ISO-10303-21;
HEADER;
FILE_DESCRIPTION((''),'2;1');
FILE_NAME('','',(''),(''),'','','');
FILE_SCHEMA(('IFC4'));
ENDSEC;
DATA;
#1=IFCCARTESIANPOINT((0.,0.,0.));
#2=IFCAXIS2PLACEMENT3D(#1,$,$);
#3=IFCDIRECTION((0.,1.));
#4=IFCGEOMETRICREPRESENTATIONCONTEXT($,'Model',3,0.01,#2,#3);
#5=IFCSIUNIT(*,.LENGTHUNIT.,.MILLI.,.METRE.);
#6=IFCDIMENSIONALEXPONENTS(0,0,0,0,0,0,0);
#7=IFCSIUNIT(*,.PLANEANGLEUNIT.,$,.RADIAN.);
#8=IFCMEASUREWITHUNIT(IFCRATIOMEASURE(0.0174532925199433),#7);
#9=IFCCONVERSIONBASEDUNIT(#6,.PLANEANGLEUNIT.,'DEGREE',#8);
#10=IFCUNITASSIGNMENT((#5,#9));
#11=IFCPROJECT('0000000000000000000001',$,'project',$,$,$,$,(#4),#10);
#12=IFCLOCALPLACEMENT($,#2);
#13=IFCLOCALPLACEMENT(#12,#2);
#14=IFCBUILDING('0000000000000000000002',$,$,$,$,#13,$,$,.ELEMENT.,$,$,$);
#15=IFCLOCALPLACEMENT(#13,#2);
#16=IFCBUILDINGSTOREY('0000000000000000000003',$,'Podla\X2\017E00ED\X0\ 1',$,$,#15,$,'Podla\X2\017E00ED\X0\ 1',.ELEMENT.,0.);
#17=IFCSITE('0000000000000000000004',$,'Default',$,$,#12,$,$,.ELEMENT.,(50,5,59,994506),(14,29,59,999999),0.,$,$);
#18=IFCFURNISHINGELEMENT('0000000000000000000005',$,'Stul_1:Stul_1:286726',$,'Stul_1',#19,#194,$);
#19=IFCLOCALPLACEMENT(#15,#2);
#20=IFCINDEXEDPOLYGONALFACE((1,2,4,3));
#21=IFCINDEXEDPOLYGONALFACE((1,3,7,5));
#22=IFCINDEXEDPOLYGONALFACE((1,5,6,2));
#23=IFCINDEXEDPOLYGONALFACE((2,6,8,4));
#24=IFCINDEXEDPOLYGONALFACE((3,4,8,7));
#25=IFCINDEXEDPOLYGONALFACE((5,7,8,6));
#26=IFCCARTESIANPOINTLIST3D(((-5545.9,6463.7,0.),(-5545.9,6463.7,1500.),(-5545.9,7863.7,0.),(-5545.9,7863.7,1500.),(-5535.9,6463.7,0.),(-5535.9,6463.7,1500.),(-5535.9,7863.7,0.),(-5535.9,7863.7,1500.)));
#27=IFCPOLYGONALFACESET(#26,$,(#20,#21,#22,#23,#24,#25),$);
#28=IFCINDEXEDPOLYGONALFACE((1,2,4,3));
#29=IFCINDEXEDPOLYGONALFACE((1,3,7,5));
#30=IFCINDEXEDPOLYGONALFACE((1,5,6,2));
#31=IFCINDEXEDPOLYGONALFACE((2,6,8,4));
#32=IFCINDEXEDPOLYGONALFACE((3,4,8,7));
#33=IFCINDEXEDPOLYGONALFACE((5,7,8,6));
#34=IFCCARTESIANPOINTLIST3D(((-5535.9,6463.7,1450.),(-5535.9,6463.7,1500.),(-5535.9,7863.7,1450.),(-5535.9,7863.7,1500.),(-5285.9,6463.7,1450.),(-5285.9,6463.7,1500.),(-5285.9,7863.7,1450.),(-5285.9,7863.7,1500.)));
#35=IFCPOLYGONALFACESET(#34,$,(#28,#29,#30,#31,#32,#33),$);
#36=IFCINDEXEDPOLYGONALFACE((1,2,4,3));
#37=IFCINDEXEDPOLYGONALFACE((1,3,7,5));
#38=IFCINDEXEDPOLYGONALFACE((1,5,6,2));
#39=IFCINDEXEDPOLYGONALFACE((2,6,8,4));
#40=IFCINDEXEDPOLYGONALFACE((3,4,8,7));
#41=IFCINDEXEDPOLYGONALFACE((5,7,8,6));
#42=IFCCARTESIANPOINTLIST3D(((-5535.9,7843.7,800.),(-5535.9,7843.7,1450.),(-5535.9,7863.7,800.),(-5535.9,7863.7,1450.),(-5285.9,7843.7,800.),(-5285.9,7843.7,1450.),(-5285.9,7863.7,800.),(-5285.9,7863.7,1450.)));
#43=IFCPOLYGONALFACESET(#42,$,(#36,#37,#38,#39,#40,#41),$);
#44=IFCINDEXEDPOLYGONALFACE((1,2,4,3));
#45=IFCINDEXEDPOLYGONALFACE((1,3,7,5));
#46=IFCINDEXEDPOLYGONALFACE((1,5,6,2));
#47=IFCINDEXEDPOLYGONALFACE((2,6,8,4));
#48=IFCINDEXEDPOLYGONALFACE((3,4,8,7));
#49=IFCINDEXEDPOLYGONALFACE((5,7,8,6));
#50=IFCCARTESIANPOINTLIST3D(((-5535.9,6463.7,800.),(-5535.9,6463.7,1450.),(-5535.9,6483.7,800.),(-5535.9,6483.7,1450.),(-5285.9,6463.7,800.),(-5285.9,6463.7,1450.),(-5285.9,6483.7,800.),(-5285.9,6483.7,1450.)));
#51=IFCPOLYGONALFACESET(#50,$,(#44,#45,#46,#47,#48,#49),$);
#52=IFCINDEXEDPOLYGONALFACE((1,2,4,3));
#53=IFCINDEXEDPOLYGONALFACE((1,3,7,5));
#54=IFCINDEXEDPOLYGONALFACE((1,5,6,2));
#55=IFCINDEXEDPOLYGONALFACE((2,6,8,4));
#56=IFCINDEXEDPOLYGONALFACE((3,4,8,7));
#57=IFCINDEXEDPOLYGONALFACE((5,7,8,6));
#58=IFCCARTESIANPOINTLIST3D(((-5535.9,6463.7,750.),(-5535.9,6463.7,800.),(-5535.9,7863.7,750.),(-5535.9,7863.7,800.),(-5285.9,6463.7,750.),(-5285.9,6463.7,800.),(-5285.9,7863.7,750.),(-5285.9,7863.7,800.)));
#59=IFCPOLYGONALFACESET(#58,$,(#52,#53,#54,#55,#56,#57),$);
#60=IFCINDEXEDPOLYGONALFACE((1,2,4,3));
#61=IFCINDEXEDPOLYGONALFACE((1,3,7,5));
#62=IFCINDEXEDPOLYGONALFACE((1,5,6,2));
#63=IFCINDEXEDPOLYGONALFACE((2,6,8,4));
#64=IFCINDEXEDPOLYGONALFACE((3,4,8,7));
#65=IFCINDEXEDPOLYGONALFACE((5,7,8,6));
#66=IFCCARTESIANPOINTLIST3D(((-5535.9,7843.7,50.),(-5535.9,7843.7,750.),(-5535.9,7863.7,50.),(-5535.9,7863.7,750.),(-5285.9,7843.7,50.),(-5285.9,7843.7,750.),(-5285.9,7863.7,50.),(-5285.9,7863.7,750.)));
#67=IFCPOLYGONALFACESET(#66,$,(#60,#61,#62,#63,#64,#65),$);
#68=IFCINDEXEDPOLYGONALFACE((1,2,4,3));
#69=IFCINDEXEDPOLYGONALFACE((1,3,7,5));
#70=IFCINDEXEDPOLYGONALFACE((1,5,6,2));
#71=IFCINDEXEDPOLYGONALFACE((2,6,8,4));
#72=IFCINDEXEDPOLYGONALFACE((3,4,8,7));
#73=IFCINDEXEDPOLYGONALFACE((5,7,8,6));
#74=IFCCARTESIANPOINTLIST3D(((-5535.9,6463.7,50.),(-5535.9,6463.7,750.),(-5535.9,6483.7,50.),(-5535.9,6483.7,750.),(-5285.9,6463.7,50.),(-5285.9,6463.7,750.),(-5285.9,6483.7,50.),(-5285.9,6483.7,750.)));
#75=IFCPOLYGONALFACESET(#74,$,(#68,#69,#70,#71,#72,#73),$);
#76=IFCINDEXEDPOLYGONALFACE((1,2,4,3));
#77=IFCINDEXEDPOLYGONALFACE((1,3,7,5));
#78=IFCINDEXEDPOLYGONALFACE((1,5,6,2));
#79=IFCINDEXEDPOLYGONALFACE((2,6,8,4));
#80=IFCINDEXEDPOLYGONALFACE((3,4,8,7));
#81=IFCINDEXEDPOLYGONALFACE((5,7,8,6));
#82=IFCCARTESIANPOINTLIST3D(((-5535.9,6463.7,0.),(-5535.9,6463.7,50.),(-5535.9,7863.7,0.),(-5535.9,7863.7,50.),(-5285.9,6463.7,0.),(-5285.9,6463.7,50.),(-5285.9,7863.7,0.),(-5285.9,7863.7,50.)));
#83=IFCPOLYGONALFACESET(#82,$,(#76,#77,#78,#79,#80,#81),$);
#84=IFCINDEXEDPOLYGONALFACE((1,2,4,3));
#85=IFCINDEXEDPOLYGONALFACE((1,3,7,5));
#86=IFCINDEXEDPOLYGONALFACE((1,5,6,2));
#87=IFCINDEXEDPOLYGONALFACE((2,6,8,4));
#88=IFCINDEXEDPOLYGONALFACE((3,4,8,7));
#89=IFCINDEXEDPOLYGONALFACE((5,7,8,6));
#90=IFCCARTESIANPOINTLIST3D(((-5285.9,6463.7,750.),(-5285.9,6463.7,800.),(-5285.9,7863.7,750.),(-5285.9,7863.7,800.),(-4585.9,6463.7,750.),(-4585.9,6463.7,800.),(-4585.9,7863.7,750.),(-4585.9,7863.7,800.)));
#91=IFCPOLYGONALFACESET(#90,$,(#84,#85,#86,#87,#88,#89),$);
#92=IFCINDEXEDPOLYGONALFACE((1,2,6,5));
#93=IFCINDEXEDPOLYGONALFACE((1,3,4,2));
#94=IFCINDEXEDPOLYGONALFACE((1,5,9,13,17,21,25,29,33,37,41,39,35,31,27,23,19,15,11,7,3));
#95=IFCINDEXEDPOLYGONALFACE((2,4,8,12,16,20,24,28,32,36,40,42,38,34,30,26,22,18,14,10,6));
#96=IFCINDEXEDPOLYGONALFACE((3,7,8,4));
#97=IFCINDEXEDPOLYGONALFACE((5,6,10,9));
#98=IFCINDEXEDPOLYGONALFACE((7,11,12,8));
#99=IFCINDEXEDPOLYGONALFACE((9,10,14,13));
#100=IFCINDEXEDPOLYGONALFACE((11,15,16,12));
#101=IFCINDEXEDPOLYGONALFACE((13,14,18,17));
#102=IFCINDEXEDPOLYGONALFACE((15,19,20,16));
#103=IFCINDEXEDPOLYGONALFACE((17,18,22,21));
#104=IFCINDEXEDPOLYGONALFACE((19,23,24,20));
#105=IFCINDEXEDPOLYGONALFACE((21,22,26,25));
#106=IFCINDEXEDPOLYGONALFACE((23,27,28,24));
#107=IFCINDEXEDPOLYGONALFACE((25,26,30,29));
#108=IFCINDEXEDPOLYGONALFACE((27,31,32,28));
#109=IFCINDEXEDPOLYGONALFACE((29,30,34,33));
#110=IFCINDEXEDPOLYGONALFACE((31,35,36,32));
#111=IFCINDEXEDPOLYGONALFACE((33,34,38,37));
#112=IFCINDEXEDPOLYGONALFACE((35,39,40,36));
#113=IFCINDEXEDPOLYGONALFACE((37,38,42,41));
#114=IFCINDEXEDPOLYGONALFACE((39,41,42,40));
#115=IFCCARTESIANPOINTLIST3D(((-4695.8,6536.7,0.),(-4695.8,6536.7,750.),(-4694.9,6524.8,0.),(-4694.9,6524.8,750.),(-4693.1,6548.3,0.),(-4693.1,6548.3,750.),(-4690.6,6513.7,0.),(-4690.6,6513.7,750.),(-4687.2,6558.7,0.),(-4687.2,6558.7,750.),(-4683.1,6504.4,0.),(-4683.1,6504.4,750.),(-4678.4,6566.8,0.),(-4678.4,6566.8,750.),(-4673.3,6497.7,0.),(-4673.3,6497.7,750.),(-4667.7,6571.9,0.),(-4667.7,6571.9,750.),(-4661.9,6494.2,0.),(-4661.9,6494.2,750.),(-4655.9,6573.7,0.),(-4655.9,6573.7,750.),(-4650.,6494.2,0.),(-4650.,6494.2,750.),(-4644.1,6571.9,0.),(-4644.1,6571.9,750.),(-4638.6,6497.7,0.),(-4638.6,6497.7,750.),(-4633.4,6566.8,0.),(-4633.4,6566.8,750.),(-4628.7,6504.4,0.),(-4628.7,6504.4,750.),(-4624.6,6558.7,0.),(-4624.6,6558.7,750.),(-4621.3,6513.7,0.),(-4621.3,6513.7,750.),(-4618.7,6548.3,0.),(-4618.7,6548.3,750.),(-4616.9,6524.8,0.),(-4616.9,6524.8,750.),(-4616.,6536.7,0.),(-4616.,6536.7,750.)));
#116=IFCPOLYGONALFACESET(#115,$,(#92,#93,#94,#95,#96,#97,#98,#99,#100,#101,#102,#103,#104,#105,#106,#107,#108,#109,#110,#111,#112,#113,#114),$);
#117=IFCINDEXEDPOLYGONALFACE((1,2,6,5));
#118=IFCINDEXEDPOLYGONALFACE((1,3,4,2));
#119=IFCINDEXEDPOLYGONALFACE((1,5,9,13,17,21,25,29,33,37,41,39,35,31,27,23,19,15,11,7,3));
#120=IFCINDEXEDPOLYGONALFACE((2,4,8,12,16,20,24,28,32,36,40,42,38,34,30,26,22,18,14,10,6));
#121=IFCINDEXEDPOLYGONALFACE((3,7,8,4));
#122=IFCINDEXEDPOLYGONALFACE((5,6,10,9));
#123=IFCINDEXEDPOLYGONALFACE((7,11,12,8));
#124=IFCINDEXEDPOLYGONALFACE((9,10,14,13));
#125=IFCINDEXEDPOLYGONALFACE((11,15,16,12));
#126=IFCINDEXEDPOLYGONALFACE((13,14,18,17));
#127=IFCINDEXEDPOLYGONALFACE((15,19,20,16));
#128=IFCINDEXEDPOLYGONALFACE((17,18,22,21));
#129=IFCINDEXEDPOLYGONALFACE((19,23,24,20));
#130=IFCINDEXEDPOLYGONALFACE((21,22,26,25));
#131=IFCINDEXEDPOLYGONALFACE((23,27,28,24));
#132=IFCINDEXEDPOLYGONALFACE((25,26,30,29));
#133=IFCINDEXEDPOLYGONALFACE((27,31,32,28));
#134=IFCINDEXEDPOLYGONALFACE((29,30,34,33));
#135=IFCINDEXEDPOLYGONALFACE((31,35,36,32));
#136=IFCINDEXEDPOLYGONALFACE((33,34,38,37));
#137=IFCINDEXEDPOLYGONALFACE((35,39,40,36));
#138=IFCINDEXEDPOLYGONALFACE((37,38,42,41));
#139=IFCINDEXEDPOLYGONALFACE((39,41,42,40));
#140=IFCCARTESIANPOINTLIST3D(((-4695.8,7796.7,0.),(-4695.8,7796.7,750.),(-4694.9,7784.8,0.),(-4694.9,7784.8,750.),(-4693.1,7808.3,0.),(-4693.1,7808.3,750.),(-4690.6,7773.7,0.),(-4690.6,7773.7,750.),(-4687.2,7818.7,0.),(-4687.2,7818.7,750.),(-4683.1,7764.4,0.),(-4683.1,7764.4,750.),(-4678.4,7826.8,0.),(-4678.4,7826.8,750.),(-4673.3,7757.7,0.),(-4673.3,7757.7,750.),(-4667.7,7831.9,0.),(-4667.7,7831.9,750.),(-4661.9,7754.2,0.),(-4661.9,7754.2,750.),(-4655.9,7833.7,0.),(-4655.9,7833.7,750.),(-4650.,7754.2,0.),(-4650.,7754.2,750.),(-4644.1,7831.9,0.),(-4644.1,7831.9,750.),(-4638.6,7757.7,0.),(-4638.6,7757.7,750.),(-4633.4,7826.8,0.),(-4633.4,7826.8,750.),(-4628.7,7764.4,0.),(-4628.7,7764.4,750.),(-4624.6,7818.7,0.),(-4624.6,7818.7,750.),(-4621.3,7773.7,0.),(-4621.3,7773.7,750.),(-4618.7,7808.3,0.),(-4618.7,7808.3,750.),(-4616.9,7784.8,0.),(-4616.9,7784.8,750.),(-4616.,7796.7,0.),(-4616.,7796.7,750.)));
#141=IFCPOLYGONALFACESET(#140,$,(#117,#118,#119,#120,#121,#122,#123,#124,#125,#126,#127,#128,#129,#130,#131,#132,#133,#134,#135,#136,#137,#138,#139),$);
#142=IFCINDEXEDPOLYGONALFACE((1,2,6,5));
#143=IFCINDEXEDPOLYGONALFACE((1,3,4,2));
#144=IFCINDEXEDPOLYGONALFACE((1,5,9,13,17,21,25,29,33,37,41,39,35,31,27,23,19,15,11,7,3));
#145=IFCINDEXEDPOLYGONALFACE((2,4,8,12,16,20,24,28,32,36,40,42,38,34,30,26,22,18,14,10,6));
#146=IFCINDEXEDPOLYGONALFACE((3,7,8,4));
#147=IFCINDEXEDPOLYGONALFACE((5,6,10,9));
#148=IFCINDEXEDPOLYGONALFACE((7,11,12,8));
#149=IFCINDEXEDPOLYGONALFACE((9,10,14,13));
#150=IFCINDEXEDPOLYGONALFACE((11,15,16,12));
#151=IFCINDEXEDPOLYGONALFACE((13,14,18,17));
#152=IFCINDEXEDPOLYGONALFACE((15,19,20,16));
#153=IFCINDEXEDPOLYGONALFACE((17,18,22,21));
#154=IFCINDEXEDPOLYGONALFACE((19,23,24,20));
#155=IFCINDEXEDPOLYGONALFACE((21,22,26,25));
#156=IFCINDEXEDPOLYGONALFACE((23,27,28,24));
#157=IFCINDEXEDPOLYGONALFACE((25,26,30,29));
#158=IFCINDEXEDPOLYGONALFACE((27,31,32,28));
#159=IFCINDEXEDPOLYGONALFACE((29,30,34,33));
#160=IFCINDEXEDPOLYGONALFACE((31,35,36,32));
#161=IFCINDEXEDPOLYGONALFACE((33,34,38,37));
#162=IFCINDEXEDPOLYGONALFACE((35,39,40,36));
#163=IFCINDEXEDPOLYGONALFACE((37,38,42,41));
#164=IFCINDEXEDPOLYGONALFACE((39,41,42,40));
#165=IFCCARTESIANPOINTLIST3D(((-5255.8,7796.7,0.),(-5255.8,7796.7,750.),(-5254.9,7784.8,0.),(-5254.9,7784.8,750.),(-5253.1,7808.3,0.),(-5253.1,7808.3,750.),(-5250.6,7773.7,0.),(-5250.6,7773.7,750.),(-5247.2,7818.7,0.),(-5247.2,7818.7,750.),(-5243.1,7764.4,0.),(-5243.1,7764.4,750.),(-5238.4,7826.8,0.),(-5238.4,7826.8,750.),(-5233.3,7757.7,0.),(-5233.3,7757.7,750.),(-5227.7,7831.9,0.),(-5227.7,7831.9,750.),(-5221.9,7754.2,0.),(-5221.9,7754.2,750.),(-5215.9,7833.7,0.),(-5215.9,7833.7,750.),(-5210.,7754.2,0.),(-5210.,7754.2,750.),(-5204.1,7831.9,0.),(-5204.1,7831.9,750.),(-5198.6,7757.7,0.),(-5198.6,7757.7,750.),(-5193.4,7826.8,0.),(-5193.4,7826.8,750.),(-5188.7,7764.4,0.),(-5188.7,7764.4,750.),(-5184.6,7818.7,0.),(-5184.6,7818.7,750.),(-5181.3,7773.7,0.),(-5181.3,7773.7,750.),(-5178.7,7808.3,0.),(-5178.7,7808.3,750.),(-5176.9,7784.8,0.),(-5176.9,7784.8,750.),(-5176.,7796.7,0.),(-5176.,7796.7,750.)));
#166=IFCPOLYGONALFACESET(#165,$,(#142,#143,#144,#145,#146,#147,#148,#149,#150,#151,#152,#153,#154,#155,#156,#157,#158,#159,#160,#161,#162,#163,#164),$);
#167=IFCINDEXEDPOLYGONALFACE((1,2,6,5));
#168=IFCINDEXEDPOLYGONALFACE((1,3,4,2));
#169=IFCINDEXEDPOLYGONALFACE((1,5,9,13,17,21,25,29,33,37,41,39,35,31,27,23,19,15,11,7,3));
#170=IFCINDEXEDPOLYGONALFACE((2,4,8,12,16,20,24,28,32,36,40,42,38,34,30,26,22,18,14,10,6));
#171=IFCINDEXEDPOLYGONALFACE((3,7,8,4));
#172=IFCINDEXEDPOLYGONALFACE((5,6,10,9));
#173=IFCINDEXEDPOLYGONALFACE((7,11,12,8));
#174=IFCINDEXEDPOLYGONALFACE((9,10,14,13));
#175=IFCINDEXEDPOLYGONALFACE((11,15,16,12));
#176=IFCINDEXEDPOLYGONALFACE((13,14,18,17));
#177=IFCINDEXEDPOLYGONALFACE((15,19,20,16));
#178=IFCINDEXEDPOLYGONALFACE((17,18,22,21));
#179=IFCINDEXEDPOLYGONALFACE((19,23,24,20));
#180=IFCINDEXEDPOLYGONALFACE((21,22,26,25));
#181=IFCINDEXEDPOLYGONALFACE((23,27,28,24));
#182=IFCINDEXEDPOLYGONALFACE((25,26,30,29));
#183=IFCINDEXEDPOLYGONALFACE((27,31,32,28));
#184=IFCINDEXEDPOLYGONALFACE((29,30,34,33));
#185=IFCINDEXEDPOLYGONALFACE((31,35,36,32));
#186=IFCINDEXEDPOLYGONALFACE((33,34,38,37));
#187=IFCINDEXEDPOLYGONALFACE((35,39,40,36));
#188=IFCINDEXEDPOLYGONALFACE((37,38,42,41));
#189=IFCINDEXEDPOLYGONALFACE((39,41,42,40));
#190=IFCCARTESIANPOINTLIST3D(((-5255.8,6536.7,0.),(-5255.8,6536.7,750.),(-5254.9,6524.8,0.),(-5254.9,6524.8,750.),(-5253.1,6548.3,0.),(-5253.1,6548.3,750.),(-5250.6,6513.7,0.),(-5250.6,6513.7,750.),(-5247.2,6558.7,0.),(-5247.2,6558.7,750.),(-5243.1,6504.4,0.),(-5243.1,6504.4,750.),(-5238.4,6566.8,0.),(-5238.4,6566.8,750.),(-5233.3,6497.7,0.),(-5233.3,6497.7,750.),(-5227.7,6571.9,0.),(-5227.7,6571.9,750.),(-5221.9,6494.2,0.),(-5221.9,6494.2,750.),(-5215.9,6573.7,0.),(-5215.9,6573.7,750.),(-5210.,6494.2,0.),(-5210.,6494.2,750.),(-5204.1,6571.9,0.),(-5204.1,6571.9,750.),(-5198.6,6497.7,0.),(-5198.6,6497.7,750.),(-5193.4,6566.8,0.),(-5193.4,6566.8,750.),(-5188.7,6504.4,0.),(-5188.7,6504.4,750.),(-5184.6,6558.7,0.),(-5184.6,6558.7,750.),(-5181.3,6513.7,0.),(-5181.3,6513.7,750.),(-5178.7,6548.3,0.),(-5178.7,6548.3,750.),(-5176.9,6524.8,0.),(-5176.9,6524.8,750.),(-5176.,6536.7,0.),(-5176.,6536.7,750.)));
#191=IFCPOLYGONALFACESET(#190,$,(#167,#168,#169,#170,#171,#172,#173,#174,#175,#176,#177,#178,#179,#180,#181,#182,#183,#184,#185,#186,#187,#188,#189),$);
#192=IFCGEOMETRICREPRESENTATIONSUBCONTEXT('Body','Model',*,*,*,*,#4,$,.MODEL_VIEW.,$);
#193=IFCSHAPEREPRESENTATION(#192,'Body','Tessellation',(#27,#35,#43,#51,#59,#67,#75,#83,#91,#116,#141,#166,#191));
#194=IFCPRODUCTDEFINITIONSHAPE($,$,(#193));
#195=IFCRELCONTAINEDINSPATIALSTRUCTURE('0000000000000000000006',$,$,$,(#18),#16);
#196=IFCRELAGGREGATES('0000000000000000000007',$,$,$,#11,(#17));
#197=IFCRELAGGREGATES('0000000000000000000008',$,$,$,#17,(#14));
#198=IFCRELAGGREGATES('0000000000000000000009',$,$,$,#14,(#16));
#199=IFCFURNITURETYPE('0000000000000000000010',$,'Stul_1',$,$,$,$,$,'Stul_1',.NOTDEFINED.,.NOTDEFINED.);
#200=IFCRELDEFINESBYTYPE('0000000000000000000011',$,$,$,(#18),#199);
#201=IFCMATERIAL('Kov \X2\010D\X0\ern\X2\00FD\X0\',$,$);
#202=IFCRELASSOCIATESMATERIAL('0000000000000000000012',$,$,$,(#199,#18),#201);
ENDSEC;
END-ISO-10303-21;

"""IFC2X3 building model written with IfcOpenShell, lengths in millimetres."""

from ifc_helpers import new_model, entity, si_unit, converted_unit, direction, frame, frame_2d, origin, origin_2d_with_axis, place, context, subcontext, project, spatial, rectangle, circle, extrude, source, transform, mapped, material, type_object, type_shapes, element, save


model = new_model("IFC2X3")

# Units and contexts
model_context = context("Model", 3, precision=0.01, world=origin(), true_north=direction((0.0, 1.0)))
body_context = subcontext(model_context, "Body", "Model", "MODEL_VIEW")
ifc_project = project(units=[si_unit("LENGTHUNIT", "METRE", prefix="MILLI"), converted_unit("PLANEANGLEUNIT", "DEGREE", entity("IfcRatioMeasure", 0.0174532925199433), si_unit("PLANEANGLEUNIT", "RADIAN"), dimensions=[0, 0, 0, 0, 0, 0, 0])], contexts=[model_context])

# Site, building, storey
site_placement = place(None, origin())
site = spatial("IfcSite", under=ifc_project, at=site_placement, Name="Default", CompositionType="ELEMENT", RefLatitude=(50, 5, 59, 994506), RefLongitude=(14, 29, 59, 999999), RefElevation=0.0)
building_placement = place(site_placement, origin())
building = spatial("IfcBuilding", under=site, at=building_placement, CompositionType="ELEMENT")
storey_placement = place(building_placement, origin())
storey = spatial("IfcBuildingStorey", under=building, at=storey_placement, Name="Podlaží 1", LongName="Podlaží 1", CompositionType="ELEMENT", Elevation=0.0)

# Furnishing element
ifc_material_1 = material(Name="Kov černý")
furniture_type = type_object("IfcFurnitureType", Name="Stul_1", ElementType="Stul_1", material=ifc_material_1)
shared_shape_1 = source(origin(), body_context, "Body", "SweptSolid", [
    extrude(rectangle(XDim=1400.0, YDim=10.0, at=origin_2d_with_axis()), frame((0.0, 605.0, 0.0), z_axis=(0.0, 0.0, 1.0), x_axis=(-1.0, 0.0, 0.0)), (0.0, 0.0, 1.0), 1500.0),
    extrude(rectangle(XDim=1400.0, YDim=250.0, at=frame_2d((0.0, 0.0), x_axis=(1.0, 0.0))), frame((0.0, 475.0, 1450.0), z_axis=(0.0, 0.0, 1.0), x_axis=(-1.0, 0.0, 0.0)), (0.0, 0.0, 1.0), 50.0),
    extrude(rectangle(XDim=20.0, YDim=250.0, at=origin_2d_with_axis()), frame((690.0, 475.0, 800.0), z_axis=(0.0, 0.0, 1.0), x_axis=(-1.0, 0.0, 0.0)), (0.0, 0.0, 1.0), 650.0),
    extrude(rectangle(XDim=20.0, YDim=250.0, at=frame_2d((0.0, 0.0), x_axis=(1.0, 0.0))), frame((-690.0, 475.0, 800.0), z_axis=(0.0, 0.0, 1.0), x_axis=(-1.0, 0.0, 0.0)), (0.0, 0.0, 1.0), 650.0),
    extrude(rectangle(XDim=1400.0, YDim=250.0, at=origin_2d_with_axis()), frame((0.0, 475.0, 750.0), z_axis=(0.0, 0.0, 1.0), x_axis=(-1.0, 0.0, 0.0)), (0.0, 0.0, 1.0), 50.0),
    extrude(rectangle(XDim=20.0, YDim=250.0, at=origin_2d_with_axis()), frame((690.0, 475.0, 50.0), z_axis=(0.0, 0.0, 1.0), x_axis=(-1.0, 0.0, 0.0)), (0.0, 0.0, 1.0), 700.0),
    extrude(rectangle(XDim=20.0, YDim=250.0, at=frame_2d((0.0, 0.0), x_axis=(1.0, 0.0))), frame((-690.0, 475.0, 50.0), z_axis=(0.0, 0.0, 1.0), x_axis=(-1.0, 0.0, 0.0)), (0.0, 0.0, 1.0), 700.0),
    extrude(rectangle(XDim=1400.0, YDim=250.0, at=origin_2d_with_axis()), frame((0.0, 475.0, 0.0), z_axis=(0.0, 0.0, 1.0), x_axis=(-1.0, 0.0, 0.0)), (0.0, 0.0, 1.0), 50.0),
    extrude(rectangle(XDim=1400.0, YDim=700.0, at=origin_2d_with_axis()), frame((0.0, 0.0, 750.0), z_axis=(0.0, 0.0, 1.0), x_axis=(-1.0, 0.0, 0.0)), (0.0, 0.0, 1.0), 50.0),
    extrude(circle(Radius=40.0, at=frame_2d((0.0, 0.0), x_axis=(1.0, 0.0))), frame((-630.0, -280.0, 0.0)), (0.0, 0.0, 1.0), 750.0),
    extrude(circle(Radius=40.0, at=frame_2d((0.0, 0.0), x_axis=(1.0, 0.0))), frame((630.0, -280.0, 0.0)), (0.0, 0.0, 1.0), 750.0),
    extrude(circle(Radius=40.0, at=frame_2d((0.0, 0.0), x_axis=(1.0, 0.0))), frame((630.0, 280.0, 0.0)), (0.0, 0.0, 1.0), 750.0),
    extrude(circle(Radius=40.0, at=frame_2d((0.0, 0.0), x_axis=(1.0, 0.0))), frame((-630.0, 280.0, 0.0)), (0.0, 0.0, 1.0), 750.0),
])
type_shapes(furniture_type, [shared_shape_1])
for number, where, z_axis, x_axis, name in (
    (1, (-4935.9, 7163.7, 0.0), (0.0, 0.0, 1.0), (0.0, 1.0, 0.0), "Stul_1:Stul_1:286726"),
):
    element("IfcFurnishingElement", number, at=place(storey_placement, frame(where, z_axis=z_axis, x_axis=x_axis)), inside=storey, type_object=furniture_type, material=ifc_material_1, Name=name, ObjectType="Stul_1", context=body_context, shape_type="MappedRepresentation", body=[
        mapped(shared_shape_1, transform((0.0, 0.0, 0.0), scale=1.0)),
    ])

save(model, "model.ifc")
